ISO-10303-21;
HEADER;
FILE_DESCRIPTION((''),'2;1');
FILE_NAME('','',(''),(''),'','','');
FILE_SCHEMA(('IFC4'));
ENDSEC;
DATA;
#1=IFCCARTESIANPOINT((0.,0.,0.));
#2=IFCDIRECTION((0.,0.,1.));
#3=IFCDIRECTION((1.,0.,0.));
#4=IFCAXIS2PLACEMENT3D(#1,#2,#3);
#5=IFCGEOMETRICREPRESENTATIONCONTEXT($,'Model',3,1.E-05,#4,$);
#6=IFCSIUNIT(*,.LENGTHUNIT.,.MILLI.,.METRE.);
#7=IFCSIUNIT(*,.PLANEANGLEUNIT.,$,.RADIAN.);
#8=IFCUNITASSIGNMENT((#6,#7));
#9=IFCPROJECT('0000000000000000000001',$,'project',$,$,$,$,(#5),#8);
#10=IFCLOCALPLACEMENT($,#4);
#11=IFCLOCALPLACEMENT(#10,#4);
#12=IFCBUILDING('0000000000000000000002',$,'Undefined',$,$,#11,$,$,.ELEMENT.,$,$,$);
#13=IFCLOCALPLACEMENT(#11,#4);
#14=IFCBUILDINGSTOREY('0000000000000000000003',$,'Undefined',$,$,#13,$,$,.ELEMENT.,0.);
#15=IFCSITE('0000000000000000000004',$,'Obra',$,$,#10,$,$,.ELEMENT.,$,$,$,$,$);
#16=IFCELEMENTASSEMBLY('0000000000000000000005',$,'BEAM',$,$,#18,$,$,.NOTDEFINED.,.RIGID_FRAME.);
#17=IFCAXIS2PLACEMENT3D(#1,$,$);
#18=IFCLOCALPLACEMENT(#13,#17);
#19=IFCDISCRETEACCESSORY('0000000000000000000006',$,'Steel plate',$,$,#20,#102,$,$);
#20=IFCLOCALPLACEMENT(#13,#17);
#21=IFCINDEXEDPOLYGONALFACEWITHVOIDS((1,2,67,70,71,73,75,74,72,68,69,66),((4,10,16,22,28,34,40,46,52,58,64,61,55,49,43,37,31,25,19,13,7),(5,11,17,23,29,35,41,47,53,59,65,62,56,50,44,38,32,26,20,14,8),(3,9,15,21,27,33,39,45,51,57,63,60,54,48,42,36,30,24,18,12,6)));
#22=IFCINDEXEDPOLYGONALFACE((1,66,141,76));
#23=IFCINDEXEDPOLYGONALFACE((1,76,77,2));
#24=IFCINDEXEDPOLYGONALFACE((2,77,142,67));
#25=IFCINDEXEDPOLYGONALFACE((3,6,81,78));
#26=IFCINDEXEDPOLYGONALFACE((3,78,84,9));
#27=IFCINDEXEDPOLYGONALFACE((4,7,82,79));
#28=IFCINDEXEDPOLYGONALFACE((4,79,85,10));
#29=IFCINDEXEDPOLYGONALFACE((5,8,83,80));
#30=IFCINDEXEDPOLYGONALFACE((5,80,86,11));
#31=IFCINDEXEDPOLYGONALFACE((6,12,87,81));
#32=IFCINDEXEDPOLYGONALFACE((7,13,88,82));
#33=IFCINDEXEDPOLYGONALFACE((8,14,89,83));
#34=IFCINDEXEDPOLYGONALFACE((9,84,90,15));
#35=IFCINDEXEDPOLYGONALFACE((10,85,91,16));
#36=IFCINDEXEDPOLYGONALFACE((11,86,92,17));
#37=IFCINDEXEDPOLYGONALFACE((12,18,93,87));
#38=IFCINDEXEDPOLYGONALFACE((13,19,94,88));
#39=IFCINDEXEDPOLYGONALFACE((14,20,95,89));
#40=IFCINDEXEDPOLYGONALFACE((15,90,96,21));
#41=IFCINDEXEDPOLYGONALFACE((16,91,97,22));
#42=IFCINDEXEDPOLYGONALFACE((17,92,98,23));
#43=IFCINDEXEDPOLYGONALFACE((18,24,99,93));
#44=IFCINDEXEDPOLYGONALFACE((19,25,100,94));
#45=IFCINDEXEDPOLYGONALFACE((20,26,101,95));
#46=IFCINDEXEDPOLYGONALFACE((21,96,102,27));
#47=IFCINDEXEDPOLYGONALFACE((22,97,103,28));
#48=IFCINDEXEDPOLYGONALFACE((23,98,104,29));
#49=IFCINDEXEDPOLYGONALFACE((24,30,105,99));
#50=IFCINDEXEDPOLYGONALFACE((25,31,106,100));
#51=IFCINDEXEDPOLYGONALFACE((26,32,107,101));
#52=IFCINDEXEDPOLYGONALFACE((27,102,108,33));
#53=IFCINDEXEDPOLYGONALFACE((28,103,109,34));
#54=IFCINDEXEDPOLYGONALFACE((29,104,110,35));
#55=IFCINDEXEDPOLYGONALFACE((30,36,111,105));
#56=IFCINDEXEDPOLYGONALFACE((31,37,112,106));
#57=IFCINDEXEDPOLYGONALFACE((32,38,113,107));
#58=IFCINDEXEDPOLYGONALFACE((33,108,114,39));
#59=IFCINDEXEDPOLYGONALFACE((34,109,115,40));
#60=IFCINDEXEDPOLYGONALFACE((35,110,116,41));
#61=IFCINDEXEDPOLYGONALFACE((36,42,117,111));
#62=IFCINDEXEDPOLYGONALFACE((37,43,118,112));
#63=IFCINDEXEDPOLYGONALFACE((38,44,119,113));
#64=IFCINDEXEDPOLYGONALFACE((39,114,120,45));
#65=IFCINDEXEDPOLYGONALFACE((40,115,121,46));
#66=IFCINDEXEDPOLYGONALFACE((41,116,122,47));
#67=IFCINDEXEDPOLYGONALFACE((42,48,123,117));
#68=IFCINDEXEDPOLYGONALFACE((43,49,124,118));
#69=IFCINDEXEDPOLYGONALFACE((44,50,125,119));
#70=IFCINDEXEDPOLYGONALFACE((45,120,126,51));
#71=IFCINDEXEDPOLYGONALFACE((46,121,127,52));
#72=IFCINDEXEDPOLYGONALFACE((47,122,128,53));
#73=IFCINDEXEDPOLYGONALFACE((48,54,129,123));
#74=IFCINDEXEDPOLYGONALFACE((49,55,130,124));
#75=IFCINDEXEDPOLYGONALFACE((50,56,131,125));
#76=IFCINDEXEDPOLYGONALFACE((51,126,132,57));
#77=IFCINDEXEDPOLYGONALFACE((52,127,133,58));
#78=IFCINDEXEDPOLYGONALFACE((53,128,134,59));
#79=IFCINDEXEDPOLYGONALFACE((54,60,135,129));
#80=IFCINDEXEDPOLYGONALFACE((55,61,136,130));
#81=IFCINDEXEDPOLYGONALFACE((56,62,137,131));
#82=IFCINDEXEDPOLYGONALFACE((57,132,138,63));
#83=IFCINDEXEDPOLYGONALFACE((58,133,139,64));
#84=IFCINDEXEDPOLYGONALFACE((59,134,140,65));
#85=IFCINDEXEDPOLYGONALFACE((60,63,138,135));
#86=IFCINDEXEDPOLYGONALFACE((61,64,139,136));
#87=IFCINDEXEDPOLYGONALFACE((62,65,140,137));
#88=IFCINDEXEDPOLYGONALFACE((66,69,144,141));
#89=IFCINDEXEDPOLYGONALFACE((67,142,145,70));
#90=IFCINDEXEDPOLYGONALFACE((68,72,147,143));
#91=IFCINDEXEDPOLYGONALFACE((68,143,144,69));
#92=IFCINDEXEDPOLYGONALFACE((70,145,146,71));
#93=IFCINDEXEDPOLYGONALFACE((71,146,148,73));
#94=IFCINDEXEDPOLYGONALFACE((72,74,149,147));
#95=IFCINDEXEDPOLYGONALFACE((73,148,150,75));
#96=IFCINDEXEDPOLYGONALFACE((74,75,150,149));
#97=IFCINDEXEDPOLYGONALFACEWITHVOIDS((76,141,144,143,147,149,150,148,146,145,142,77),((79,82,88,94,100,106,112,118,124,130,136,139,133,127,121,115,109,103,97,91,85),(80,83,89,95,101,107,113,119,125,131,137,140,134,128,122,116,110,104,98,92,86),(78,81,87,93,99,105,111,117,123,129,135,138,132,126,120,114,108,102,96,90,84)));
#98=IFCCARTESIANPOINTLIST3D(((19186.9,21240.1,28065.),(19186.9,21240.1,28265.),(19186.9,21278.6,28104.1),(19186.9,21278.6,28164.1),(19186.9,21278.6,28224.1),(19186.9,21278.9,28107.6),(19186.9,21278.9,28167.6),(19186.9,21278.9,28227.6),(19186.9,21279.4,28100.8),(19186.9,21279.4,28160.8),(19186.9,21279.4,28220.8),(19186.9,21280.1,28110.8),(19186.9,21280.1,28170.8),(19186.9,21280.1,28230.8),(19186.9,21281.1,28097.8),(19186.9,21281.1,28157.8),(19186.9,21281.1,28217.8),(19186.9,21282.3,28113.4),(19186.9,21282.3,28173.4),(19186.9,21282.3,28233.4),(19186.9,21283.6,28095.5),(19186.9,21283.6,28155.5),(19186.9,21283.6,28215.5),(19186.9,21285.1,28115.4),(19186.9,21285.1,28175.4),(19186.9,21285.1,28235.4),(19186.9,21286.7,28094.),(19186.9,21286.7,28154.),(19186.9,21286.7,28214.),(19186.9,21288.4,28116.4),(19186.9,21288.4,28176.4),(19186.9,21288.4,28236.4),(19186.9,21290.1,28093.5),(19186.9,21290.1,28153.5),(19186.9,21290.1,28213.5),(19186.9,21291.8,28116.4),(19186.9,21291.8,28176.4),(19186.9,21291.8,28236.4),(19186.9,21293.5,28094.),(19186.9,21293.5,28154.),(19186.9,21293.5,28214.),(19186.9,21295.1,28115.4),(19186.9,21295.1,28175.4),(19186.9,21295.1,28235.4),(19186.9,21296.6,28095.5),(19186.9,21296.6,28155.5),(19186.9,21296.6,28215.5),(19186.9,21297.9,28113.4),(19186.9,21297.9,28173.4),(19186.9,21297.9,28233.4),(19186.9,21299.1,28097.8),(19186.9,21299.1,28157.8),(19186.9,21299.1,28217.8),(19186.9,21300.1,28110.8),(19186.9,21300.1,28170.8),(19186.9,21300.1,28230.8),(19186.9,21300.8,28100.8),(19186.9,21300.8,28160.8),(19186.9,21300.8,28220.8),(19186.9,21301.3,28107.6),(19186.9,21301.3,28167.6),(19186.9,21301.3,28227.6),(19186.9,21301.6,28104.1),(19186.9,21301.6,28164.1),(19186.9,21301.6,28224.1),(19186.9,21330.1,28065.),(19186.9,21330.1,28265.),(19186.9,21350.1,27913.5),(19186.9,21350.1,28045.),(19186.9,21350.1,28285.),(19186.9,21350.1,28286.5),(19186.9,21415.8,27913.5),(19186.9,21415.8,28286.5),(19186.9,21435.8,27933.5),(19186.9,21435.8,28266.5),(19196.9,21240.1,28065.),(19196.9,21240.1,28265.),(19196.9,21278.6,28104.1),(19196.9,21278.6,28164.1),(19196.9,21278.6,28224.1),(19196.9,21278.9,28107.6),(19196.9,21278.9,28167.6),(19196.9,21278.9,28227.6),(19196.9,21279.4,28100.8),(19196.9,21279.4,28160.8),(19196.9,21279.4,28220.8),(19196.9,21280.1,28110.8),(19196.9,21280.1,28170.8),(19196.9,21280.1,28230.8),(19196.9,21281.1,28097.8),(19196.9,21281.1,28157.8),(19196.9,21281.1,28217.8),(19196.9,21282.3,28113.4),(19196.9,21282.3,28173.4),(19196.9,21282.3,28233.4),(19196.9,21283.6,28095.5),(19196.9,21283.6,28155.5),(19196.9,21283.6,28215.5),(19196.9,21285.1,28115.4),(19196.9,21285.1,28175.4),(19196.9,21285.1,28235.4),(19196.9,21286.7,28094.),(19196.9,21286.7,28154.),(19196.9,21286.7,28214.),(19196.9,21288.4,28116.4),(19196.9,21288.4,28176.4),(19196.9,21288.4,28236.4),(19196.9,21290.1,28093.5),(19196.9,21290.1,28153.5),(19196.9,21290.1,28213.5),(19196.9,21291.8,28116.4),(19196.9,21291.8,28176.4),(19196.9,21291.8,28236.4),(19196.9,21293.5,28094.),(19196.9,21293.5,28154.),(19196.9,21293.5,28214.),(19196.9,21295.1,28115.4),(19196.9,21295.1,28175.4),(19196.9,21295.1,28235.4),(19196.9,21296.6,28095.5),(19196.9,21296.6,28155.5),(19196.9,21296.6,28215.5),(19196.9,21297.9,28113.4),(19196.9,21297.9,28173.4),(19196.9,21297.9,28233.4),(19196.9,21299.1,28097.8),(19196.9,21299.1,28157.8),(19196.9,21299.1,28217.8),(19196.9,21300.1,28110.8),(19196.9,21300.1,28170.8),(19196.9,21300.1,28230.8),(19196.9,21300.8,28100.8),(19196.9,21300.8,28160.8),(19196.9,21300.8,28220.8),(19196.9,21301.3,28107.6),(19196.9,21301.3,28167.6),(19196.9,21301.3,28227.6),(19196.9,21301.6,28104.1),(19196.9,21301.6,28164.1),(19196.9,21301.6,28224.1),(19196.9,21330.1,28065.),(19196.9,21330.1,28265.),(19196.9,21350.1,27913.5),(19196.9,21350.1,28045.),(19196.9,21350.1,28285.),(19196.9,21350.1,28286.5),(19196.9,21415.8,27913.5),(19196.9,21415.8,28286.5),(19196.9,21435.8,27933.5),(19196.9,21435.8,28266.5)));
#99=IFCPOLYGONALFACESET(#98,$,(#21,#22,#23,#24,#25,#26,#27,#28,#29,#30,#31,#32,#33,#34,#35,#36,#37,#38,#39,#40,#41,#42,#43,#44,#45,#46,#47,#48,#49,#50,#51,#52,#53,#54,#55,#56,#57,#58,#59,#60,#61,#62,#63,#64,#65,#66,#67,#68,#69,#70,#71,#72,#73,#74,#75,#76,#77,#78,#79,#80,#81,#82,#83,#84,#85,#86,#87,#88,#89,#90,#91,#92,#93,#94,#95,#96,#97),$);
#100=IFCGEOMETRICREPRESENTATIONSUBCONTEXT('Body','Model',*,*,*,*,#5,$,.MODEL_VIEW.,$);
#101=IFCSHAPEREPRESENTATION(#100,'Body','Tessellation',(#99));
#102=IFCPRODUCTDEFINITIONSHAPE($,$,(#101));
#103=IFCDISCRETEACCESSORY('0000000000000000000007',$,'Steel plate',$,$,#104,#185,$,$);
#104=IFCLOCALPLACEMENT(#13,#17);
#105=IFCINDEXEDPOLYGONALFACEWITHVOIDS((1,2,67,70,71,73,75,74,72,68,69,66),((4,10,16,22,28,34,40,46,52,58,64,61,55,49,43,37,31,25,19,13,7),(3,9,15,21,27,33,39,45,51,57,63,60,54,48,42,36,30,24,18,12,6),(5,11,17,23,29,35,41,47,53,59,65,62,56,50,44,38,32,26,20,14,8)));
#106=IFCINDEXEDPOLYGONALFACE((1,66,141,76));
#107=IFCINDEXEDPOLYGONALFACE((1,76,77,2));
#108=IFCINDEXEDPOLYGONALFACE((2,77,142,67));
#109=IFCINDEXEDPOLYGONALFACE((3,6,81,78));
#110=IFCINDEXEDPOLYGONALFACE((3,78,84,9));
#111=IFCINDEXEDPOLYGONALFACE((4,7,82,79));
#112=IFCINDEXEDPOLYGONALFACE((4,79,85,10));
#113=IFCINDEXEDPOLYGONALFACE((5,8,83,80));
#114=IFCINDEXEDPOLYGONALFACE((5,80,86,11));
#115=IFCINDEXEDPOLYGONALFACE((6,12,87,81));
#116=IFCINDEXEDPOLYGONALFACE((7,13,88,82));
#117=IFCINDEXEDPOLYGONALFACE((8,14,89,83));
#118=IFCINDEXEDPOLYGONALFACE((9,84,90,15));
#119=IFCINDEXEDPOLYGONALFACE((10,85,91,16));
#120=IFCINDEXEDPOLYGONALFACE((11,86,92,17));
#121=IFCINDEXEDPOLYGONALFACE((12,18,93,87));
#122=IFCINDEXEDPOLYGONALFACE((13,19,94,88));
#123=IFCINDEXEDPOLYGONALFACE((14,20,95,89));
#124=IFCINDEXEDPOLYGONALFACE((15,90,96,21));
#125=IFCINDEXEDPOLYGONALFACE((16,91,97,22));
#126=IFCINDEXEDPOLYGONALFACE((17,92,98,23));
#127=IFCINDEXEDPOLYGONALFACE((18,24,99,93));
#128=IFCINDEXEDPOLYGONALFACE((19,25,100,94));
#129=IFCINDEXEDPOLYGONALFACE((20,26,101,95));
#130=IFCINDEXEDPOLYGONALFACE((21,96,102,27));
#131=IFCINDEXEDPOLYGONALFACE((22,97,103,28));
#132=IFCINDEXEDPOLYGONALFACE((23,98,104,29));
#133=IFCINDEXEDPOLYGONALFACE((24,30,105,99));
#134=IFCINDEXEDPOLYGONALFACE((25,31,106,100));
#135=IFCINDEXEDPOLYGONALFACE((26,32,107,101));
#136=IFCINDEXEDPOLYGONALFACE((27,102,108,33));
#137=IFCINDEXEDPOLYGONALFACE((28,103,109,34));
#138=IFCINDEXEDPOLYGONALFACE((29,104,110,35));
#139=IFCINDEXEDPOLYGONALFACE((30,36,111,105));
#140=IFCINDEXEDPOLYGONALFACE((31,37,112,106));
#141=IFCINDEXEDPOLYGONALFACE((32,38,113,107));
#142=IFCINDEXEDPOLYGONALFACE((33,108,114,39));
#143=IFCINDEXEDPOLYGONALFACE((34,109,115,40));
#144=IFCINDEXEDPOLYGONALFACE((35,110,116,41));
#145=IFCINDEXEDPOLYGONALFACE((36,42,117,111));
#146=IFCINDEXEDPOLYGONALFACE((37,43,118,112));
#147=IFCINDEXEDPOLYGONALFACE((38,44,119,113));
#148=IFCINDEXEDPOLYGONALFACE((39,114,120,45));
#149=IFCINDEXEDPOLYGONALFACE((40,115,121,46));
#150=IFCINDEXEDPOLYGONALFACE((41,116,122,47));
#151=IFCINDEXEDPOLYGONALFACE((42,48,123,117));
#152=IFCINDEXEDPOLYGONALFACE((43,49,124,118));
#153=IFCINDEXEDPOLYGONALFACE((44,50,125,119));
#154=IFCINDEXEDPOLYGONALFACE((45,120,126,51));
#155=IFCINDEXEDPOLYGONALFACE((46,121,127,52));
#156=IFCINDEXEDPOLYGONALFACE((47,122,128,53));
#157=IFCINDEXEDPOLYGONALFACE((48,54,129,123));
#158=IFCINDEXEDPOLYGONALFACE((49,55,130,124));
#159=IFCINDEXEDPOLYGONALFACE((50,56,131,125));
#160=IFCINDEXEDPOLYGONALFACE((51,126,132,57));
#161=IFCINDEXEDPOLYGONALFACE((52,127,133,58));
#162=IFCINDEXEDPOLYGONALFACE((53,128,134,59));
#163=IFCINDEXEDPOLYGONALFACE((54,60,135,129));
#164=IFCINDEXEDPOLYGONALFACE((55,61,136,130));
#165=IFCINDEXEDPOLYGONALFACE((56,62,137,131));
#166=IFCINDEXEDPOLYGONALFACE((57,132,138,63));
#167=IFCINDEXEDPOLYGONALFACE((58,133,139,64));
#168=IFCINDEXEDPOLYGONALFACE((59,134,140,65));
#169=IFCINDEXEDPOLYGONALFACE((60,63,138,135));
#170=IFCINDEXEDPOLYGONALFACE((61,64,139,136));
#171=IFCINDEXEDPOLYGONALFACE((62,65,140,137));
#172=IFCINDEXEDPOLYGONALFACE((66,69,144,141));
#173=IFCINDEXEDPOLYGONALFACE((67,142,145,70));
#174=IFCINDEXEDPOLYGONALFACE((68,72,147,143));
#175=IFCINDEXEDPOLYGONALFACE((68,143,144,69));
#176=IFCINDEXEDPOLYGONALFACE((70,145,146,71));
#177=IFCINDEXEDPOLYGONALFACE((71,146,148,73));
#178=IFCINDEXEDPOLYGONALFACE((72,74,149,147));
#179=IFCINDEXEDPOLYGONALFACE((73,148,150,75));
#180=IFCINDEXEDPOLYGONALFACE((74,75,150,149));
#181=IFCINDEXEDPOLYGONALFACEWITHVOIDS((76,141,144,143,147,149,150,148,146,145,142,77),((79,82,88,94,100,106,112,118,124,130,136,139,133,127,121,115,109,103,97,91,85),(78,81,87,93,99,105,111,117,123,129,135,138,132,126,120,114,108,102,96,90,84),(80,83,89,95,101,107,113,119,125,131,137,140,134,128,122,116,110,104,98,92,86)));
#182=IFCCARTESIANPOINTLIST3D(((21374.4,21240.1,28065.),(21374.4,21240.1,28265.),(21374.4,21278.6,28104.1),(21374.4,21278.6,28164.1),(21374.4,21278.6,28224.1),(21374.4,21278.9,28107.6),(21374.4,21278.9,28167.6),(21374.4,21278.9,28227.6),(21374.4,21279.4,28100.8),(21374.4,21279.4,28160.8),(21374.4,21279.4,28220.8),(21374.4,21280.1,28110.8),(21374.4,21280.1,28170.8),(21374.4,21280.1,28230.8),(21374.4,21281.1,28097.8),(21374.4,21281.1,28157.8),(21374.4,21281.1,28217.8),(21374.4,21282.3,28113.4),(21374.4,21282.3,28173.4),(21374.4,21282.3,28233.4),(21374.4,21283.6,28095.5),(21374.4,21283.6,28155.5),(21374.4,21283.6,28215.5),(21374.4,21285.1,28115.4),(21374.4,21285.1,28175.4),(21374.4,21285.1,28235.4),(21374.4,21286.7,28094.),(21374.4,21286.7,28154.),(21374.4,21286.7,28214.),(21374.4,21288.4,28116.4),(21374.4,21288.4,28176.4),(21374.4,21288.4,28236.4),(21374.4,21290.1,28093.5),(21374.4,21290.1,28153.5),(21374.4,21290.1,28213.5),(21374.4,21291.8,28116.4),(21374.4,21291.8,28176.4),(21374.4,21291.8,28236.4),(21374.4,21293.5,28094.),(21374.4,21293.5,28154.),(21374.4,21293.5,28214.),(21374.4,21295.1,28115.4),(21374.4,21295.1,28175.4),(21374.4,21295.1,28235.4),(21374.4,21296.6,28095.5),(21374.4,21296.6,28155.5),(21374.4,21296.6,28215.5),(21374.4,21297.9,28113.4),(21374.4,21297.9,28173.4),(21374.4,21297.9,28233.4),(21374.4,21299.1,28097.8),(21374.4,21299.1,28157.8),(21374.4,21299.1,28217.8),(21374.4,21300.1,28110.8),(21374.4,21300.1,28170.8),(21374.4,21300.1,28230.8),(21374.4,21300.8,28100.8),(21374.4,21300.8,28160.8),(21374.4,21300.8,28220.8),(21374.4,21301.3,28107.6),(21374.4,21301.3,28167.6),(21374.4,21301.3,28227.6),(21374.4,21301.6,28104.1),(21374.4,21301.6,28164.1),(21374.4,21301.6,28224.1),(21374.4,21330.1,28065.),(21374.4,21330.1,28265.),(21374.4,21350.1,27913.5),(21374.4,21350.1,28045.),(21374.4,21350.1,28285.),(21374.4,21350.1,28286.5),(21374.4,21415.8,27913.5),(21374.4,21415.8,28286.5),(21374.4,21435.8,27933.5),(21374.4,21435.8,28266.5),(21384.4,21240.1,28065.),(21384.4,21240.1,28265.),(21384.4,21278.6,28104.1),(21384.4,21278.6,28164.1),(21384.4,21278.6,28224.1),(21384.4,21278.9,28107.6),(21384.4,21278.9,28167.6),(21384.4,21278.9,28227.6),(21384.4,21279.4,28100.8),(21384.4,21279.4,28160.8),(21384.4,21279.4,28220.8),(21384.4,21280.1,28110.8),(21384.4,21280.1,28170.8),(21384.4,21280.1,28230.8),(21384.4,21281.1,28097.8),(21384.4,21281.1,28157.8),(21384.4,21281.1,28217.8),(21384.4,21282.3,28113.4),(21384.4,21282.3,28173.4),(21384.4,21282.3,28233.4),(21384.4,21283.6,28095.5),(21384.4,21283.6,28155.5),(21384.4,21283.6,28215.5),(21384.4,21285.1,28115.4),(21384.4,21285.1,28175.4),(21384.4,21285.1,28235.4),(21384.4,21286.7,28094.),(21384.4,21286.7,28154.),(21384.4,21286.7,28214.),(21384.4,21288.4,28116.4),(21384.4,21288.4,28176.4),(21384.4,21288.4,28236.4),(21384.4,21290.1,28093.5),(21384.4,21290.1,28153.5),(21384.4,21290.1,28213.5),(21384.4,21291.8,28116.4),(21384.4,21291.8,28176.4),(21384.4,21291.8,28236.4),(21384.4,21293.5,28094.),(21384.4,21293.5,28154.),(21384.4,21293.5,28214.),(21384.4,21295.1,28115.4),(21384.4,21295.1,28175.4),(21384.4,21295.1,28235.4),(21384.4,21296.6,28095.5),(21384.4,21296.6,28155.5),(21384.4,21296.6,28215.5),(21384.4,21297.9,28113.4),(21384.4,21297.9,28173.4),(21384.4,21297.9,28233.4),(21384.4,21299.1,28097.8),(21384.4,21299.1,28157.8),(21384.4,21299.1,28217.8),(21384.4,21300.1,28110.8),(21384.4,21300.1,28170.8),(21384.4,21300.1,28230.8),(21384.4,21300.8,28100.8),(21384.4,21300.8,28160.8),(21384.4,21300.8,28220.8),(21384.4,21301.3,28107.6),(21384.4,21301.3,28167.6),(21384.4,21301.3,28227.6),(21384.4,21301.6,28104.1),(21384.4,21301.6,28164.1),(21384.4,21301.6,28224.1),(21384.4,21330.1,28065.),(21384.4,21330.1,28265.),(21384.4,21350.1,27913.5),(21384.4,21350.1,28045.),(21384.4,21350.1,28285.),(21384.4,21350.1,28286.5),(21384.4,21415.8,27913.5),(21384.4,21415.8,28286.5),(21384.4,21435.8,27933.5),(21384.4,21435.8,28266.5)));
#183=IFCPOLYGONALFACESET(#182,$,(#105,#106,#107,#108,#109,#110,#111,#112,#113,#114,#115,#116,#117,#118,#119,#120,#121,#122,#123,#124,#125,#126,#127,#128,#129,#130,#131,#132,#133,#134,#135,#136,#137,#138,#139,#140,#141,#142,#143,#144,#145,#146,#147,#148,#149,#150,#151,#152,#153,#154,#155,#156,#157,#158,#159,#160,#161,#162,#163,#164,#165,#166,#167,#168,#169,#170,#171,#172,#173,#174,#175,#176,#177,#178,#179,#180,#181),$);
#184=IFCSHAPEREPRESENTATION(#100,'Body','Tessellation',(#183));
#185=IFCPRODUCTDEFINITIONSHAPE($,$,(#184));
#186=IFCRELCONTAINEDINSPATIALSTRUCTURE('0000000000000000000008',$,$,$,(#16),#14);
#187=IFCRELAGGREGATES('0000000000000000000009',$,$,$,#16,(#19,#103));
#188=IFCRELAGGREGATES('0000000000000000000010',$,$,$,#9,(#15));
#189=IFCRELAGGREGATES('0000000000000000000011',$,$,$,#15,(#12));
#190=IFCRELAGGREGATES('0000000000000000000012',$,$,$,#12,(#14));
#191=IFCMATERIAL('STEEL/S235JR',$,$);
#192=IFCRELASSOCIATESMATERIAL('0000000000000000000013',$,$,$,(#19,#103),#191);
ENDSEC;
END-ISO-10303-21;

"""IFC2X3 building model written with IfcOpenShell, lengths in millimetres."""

from ifc_helpers import new_model, si_unit, frame, origin_with_axes, origin_2d_with_axis, place, context, subcontext, project, spatial, polyline, circle, outline, extrude, source, transform, mapped, material, element, aggregate, save


model = new_model("IFC2X3")

# Units and contexts
model_context = context("Model", 3, precision=1e-05, world=origin_with_axes())
body_context = subcontext(model_context, "Body", "Model", "MODEL_VIEW")
ifc_project = project(units=[si_unit("LENGTHUNIT", "METRE", prefix="MILLI"), si_unit("PLANEANGLEUNIT", "RADIAN")], contexts=[model_context])

# Site, building, storey
site_placement = place(None, origin_with_axes())
site = spatial("IfcSite", under=ifc_project, at=site_placement, Name="Obra", CompositionType="ELEMENT")
building_placement = place(site_placement, origin_with_axes())
building = spatial("IfcBuilding", under=site, at=building_placement, Name="Undefined", CompositionType="ELEMENT")
storey_placement = place(building_placement, origin_with_axes())
storey = spatial("IfcBuildingStorey", under=building, at=storey_placement, Name="Undefined", CompositionType="ELEMENT", Elevation=0.0)

# Shared definitions
ifc_material = material(Name="STEEL/S235JR")

# Element assembly, discrete accessories, openings
assembly_1_placement = place(storey_placement, origin_with_axes())
assembly_1 = element("IfcElementAssembly", 1, at=assembly_1_placement, inside=storey, Name="BEAM", AssemblyPlace="NOTDEFINED", PredefinedType="RIGID_FRAME")
discrete_accessory_1_placement = place(assembly_1_placement, frame((19191.9, 21435.8, 27933.5), z_axis=(-1.0, 0.0, 0.0), x_axis=(0.000001, -0.707107, -0.707107)))
discrete_accessory_1 = element("IfcDiscreteAccessory", 2, at=discrete_accessory_1_placement, material=ifc_material, Name="Steel plate", context=body_context, shape_type="SweptSolid", body=[
    extrude(outline(polyline([(0.0, 0.0), (28.3, 0.0), (74.7, 46.5), (-18.2, 139.4), (-18.2, 167.7), (45.4, 231.4), (-96.0, 372.8), (-159.7, 309.1), (-187.9, 309.1), (-189.0, 310.2), (-235.5, 263.8), (-235.5, 235.5), (0.0, 0.0)])), frame((0.0, 0.0, -5.0), z_axis=(0.0, 0.0, 1.0), x_axis=(1.0, 0.0, 0.0)), (0.0, 0.0, 1.0), 10.0),
])
shared_shape_1 = source(origin_with_axes(), body_context, "Body", "SweptSolid", [
    extrude(circle(Radius=11.5, at=origin_2d_with_axis()), frame((0.0, -13.4, 0.0), z_axis=(0.0, 1.0, 0.0), x_axis=(1.0, 0.0, 0.0)), (0.0, 0.0, 1.0), 10.2),
])
opening_1_placement = place(assembly_1_placement, frame((19200.2, 21340.1, 28265.0), z_axis=(0.0, -1.0, 0.0), x_axis=(0.0, 0.0, -1.0)))
element("IfcOpeningElement", 3, at=opening_1_placement, cuts=discrete_accessory_1, ObjectType="Opening", context=body_context, shape_type="MappedRepresentation", body=[
    mapped(shared_shape_1, transform((40.0, 0.0, 50.0))),
    mapped(shared_shape_1, transform((100.0, 0.0, 50.0))),
    mapped(shared_shape_1, transform((160.0, 0.0, 50.0))),
])
discrete_accessory_2_placement = place(assembly_1_placement, frame((21379.4, 21435.8, 27933.5), z_axis=(-1.0, 0.0, 0.0), x_axis=(0.000001, -0.707107, -0.707107)))
discrete_accessory_2 = element("IfcDiscreteAccessory", 4, at=discrete_accessory_2_placement, material=ifc_material, Name="Steel plate", context=body_context, shape_type="SweptSolid", body=[
    extrude(outline(polyline([(0.0, 0.0), (28.3, 0.0), (74.7, 46.5), (-18.2, 139.4), (-18.2, 167.7), (45.4, 231.4), (-96.0, 372.8), (-159.7, 309.1), (-187.9, 309.1), (-189.0, 310.2), (-235.5, 263.8), (-235.5, 235.5), (0.0, 0.0)])), frame((0.0, 0.0, -5.0), z_axis=(0.0, 0.0, 1.0), x_axis=(1.0, 0.0, 0.0)), (0.0, 0.0, 1.0), 10.0),
])
opening_2_placement = place(assembly_1_placement, frame((21387.7, 21340.1, 28265.0), z_axis=(0.0, -1.0, 0.0), x_axis=(0.0, 0.0, -1.0)))
element("IfcOpeningElement", 5, at=opening_2_placement, cuts=discrete_accessory_2, ObjectType="Opening", context=body_context, shape_type="MappedRepresentation", body=[
    mapped(shared_shape_1, transform((40.0, 0.0, 50.0))),
    mapped(shared_shape_1, transform((100.0, 0.0, 50.0))),
    mapped(shared_shape_1, transform((160.0, 0.0, 50.0))),
])
aggregate(assembly_1, [discrete_accessory_1, discrete_accessory_2])

save(model, "model.ifc")
